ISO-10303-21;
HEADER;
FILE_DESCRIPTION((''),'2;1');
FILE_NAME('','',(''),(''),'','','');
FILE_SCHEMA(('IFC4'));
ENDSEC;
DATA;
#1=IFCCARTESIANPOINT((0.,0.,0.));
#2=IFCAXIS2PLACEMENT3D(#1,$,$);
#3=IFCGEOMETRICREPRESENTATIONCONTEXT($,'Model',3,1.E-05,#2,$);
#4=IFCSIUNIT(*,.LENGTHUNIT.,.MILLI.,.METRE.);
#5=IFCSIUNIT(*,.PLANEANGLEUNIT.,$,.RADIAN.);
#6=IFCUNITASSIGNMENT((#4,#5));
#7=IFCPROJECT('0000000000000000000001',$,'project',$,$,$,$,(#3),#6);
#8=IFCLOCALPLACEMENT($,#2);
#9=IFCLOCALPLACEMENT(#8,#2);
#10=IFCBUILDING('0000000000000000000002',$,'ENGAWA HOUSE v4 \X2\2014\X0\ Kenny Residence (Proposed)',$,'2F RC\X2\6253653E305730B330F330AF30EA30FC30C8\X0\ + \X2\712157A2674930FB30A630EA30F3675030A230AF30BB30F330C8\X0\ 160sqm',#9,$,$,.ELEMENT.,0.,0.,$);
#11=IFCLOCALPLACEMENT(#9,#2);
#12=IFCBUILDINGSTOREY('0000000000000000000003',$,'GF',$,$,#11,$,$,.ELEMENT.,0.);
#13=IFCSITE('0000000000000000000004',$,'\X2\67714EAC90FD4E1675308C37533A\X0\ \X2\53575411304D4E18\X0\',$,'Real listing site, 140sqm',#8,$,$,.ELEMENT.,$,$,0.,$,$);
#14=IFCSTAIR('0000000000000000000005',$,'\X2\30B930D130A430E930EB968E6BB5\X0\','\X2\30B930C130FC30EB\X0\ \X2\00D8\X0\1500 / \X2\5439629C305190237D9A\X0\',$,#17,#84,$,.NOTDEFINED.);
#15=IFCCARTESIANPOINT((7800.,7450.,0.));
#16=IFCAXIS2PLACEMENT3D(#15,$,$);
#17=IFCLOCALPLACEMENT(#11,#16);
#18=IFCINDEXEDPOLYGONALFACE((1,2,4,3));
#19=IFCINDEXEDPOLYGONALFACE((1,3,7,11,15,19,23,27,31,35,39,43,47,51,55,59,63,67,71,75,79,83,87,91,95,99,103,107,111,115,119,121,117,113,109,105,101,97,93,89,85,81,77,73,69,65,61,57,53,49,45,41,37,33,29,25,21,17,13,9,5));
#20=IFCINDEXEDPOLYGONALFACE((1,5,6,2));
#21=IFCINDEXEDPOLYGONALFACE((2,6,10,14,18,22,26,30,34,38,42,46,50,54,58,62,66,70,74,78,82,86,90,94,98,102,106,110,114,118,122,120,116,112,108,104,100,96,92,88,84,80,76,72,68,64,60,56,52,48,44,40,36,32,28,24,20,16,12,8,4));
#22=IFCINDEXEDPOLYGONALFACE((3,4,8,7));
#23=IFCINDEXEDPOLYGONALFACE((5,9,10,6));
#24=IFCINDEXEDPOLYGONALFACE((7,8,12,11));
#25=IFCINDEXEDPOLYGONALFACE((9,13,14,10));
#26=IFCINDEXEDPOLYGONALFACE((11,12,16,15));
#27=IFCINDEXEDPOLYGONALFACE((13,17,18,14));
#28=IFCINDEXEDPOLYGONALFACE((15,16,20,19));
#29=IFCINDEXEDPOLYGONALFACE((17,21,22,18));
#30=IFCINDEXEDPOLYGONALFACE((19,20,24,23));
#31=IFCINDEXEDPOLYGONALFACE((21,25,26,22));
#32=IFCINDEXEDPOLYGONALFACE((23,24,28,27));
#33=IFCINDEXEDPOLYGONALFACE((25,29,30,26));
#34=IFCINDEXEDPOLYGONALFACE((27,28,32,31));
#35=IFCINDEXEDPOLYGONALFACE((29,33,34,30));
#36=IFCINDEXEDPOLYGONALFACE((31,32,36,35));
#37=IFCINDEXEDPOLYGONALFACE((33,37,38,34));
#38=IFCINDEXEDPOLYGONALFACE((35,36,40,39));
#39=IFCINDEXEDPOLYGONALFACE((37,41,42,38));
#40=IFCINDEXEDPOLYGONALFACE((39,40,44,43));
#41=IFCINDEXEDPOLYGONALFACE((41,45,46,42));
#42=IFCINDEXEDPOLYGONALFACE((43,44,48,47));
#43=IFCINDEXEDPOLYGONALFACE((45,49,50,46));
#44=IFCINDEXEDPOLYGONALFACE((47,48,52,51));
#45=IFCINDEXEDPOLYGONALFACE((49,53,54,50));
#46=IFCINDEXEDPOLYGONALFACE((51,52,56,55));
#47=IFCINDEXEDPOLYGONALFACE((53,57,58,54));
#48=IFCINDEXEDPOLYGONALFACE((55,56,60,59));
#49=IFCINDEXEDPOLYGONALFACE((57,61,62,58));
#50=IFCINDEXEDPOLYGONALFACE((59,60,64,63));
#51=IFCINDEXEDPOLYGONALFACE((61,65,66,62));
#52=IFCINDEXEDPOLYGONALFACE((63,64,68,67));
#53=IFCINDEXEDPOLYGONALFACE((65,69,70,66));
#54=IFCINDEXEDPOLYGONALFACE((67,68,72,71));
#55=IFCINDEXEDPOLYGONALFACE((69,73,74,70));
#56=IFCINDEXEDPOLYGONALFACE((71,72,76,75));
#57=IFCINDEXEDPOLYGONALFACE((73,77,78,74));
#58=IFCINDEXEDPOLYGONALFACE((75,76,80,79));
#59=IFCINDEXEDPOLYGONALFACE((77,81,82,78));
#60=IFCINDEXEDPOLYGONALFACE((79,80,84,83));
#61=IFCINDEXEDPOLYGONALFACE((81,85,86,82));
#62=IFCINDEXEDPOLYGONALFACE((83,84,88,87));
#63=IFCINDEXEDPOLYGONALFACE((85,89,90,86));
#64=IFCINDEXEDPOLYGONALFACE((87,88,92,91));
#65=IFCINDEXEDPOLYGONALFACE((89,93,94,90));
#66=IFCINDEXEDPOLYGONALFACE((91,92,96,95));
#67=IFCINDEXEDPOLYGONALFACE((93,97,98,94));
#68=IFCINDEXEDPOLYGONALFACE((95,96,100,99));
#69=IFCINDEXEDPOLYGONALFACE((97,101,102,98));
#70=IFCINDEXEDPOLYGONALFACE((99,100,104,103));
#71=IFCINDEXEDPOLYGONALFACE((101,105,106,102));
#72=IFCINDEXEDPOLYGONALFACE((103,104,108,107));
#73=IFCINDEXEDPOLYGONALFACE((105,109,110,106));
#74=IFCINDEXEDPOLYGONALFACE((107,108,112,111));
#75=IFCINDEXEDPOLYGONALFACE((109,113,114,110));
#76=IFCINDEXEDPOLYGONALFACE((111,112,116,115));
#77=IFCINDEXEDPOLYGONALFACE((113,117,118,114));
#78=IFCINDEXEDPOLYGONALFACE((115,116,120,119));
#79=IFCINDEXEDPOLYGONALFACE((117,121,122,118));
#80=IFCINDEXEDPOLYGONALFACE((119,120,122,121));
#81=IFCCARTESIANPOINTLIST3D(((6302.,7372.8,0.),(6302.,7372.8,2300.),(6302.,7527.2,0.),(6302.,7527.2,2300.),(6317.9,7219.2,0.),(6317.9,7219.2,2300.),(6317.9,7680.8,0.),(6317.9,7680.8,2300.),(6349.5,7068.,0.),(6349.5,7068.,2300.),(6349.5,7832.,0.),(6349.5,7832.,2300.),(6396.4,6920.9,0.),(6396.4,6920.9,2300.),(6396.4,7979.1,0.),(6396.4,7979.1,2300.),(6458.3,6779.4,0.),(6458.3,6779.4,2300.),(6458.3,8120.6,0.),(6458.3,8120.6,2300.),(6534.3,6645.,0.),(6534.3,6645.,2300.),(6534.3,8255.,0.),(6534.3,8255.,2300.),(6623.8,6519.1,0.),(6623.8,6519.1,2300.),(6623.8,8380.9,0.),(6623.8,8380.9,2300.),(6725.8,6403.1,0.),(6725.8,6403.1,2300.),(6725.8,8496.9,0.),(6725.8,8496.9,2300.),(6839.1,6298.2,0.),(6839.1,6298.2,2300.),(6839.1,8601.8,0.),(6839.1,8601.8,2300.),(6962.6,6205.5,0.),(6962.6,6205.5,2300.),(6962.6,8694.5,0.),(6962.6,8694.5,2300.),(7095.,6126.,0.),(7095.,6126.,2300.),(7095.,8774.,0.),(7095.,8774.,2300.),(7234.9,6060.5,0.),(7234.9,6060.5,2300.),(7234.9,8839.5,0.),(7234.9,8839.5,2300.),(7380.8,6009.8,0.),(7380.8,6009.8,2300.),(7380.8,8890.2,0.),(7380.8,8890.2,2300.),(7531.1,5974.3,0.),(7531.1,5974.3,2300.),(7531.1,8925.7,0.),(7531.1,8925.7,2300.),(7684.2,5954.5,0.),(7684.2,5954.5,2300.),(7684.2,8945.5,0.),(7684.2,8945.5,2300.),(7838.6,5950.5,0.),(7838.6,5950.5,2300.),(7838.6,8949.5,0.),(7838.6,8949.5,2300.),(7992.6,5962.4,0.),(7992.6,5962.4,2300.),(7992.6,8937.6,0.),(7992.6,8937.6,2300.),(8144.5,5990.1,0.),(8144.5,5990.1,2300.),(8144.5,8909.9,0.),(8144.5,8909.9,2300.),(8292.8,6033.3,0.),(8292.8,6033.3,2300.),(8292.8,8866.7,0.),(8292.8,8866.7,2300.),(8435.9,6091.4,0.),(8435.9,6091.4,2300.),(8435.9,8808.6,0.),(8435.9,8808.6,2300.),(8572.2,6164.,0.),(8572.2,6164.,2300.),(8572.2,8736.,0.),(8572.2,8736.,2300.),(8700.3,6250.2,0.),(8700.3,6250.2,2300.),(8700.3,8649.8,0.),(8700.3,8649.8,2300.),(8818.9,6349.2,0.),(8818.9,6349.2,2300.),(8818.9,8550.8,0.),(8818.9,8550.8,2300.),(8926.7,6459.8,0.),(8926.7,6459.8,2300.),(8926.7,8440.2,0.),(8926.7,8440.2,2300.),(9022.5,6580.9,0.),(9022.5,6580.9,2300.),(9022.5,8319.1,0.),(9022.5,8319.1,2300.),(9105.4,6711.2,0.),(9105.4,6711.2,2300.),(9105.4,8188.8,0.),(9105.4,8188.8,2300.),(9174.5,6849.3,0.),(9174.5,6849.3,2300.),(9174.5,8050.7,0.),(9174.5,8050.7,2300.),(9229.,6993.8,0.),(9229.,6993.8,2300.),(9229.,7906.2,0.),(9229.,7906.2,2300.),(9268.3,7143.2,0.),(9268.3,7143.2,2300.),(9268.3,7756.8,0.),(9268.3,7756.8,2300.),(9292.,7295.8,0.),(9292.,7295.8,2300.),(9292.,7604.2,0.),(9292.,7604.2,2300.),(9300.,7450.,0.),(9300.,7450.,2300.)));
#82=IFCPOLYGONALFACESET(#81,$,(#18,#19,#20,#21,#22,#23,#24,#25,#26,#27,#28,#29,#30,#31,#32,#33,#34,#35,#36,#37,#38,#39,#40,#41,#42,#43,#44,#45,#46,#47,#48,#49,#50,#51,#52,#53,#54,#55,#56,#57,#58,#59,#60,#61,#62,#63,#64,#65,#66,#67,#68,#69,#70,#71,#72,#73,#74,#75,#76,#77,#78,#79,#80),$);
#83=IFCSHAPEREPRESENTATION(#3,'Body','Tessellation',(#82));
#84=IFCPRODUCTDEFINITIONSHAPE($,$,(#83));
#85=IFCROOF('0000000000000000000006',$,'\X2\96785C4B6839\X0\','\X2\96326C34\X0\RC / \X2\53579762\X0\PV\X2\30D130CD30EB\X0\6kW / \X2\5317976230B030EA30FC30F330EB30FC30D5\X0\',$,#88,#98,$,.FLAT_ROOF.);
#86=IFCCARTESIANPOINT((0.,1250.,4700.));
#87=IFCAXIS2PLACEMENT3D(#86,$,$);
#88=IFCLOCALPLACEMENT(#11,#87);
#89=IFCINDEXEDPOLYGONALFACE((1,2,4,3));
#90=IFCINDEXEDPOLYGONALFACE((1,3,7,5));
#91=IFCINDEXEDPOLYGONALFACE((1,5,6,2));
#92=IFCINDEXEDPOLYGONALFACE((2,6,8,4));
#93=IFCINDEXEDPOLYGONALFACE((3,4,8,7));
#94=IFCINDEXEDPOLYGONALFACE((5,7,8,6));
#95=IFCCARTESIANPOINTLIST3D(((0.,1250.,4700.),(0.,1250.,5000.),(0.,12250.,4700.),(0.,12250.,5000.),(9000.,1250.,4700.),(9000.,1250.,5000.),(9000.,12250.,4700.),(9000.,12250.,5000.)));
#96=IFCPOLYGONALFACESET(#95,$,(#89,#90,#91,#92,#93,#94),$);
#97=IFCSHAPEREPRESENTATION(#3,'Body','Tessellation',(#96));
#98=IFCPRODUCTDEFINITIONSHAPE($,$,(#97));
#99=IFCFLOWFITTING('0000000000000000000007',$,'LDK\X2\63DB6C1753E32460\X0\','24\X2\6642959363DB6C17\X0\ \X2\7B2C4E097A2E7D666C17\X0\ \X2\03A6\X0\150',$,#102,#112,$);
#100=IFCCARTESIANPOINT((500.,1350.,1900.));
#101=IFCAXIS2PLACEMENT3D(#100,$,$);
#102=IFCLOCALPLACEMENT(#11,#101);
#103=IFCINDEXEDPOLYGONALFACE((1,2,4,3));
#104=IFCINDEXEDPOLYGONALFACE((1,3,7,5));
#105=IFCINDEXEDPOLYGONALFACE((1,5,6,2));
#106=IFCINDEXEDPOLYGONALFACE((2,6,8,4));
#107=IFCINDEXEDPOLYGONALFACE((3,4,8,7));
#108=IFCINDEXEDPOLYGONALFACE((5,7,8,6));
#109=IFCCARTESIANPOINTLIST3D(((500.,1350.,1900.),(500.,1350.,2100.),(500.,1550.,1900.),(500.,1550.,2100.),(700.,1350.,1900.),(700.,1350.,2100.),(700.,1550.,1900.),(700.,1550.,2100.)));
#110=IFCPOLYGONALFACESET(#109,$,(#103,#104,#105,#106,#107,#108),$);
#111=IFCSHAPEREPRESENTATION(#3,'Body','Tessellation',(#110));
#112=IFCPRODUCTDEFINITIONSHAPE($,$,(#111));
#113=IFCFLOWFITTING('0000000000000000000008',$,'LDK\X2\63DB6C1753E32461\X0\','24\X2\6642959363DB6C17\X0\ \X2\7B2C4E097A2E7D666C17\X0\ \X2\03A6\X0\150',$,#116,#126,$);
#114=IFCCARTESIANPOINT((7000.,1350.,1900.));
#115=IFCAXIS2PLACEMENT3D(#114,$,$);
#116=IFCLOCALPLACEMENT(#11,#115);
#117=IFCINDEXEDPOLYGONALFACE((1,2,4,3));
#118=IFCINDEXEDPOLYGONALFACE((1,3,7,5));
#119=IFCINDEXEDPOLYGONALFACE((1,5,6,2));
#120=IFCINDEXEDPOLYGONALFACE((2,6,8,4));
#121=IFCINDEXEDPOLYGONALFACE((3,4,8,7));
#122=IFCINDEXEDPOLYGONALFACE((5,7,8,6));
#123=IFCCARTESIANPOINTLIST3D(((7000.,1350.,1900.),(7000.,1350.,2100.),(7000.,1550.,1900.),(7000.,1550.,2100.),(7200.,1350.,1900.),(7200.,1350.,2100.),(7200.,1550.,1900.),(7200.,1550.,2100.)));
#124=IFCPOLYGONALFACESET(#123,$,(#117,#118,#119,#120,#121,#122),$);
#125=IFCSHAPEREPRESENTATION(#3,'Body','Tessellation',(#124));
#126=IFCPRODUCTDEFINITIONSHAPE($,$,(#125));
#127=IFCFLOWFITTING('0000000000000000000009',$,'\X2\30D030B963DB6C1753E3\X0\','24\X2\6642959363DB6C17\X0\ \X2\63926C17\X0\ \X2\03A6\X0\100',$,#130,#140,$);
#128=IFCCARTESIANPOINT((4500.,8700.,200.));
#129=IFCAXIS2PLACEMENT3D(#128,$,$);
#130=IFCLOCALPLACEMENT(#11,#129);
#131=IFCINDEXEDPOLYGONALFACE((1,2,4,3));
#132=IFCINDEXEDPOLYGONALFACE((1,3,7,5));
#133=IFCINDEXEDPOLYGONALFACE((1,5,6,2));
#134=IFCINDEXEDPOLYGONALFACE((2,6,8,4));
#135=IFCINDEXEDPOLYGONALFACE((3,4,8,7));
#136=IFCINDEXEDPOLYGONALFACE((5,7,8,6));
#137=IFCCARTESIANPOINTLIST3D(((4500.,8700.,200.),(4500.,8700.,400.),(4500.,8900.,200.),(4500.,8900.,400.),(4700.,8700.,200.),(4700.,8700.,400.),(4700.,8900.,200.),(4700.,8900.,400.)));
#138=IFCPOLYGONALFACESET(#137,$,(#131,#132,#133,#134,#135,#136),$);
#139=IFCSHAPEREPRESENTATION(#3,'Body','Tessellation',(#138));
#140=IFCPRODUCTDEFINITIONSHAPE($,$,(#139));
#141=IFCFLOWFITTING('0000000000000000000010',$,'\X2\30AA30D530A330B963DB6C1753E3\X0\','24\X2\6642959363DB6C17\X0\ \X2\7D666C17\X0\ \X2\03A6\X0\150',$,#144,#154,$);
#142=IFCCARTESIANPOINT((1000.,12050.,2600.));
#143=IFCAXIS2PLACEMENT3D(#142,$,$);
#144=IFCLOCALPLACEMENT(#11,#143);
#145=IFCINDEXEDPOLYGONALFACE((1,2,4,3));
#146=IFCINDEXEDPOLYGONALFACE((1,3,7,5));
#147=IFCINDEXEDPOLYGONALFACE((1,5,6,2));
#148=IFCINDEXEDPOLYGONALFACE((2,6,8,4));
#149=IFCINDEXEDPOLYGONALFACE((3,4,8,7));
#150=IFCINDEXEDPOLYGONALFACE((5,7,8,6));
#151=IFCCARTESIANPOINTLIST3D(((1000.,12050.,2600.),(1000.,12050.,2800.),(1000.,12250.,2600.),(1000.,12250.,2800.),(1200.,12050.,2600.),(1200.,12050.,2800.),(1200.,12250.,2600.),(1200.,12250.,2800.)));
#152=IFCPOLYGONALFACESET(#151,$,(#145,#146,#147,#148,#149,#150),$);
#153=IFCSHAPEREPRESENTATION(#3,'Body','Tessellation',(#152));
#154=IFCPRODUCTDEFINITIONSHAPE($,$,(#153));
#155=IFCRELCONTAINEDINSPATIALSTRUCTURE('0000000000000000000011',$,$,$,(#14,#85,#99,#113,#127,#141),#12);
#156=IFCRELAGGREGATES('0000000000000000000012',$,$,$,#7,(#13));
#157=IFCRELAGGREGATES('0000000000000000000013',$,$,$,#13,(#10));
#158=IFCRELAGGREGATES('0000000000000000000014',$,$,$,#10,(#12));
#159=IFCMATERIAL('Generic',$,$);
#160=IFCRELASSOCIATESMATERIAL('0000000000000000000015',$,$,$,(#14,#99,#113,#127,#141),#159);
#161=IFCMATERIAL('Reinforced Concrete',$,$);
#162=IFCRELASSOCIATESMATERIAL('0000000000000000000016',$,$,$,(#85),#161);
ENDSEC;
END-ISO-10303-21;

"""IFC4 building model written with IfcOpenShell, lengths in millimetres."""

from ifc_helpers import new_model, si_unit, frame, frame_2d, origin, origin_2d, place, context, project, spatial, rectangle, circle, extrude, material, element, save


model = new_model("IFC4")

# Units and contexts
model_context = context("Model", 3, precision=1e-05, world=origin())
ifc_project = project(units=[si_unit("LENGTHUNIT", "METRE", prefix="MILLI"), si_unit("PLANEANGLEUNIT", "RADIAN")], contexts=[model_context])

# Site, building, storey
site_placement = place(None, origin())
site = spatial("IfcSite", under=ifc_project, at=site_placement, Name="東京都世田谷区 南向き丘", ObjectType="Real listing site, 140sqm", CompositionType="ELEMENT", RefElevation=0.0)
building_placement = place(site_placement, origin())
building = spatial("IfcBuilding", under=site, at=building_placement, Name="ENGAWA HOUSE v4 — Kenny Residence (Proposed)", ObjectType="2F RC打放しコンクリート + 無垢杉・ウリン材アクセント 160sqm", CompositionType="ELEMENT", ElevationOfRefHeight=0.0, ElevationOfTerrain=0.0)
storey_placement = place(building_placement, origin())
storey = spatial("IfcBuildingStorey", under=building, at=storey_placement, Name="GF", CompositionType="ELEMENT", Elevation=0.0)

# Shared definitions
ifc_material_1 = material(Name="Reinforced Concrete")
ifc_material_2 = material(Name="Generic")

# Stair
stair_placement = place(storey_placement, frame((7800.0, 7450.0, 0.0)))
element("IfcStair", 1, at=stair_placement, inside=storey, material=ifc_material_2, Name="スパイラル階段", Description="スチール Ø1500 / 吹抜け連続", PredefinedType="NOTDEFINED", context=model_context, shape_type="SweptSolid", body=[
    extrude(circle(Radius=1500.0, at=origin_2d()), frame((7800.0, 7450.0, 0.0)), (0.0, 0.0, 1.0), 2300.0),
])

# Roof
roof_placement = place(storey_placement, frame((0.0, 1250.0, 4700.0)))
element("IfcRoof", 2, at=roof_placement, inside=storey, material=ifc_material_1, Name="陸屋根", Description="防水RC / 南面PVパネル6kW / 北面グリーンルーフ", PredefinedType="FLAT_ROOF", context=model_context, shape_type="SweptSolid", body=[
    extrude(rectangle(XDim=9000.0, YDim=11000.0, at=frame_2d((4500.0, 5500.0))), frame((0.0, 1250.0, 4700.0)), (0.0, 0.0, 1.0), 300.0),
])

# Flow fittings
flow_fitting_1_placement = place(storey_placement, frame((500.0, 1350.0, 1900.0)))
element("IfcFlowFitting", 3, at=flow_fitting_1_placement, inside=storey, material=ifc_material_2, Name="LDK換気口①", Description="24時間換気 第三種給気 Φ150", context=model_context, shape_type="SweptSolid", body=[
    extrude(rectangle(XDim=200.0, YDim=200.0, at=frame_2d((100.0, 100.0))), frame((500.0, 1350.0, 1900.0)), (0.0, 0.0, 1.0), 200.0),
])
flow_fitting_2_placement = place(storey_placement, frame((7000.0, 1350.0, 1900.0)))
element("IfcFlowFitting", 4, at=flow_fitting_2_placement, inside=storey, material=ifc_material_2, Name="LDK換気口②", Description="24時間換気 第三種給気 Φ150", context=model_context, shape_type="SweptSolid", body=[
    extrude(rectangle(XDim=200.0, YDim=200.0, at=frame_2d((100.0, 100.0))), frame((7000.0, 1350.0, 1900.0)), (0.0, 0.0, 1.0), 200.0),
])
flow_fitting_3_placement = place(storey_placement, frame((4500.0, 8700.0, 200.0)))
element("IfcFlowFitting", 5, at=flow_fitting_3_placement, inside=storey, material=ifc_material_2, Name="バス換気口", Description="24時間換気 排気 Φ100", context=model_context, shape_type="SweptSolid", body=[
    extrude(rectangle(XDim=200.0, YDim=200.0, at=frame_2d((100.0, 100.0))), frame((4500.0, 8700.0, 200.0)), (0.0, 0.0, 1.0), 200.0),
])
flow_fitting_4_placement = place(storey_placement, frame((1000.0, 12050.0, 2600.0)))
element("IfcFlowFitting", 6, at=flow_fitting_4_placement, inside=storey, material=ifc_material_2, Name="オフィス換気口", Description="24時間換気 給気 Φ150", context=model_context, shape_type="SweptSolid", body=[
    extrude(rectangle(XDim=200.0, YDim=200.0, at=frame_2d((100.0, 100.0))), frame((1000.0, 12050.0, 2600.0)), (0.0, 0.0, 1.0), 200.0),
])

save(model, "model.ifc")
